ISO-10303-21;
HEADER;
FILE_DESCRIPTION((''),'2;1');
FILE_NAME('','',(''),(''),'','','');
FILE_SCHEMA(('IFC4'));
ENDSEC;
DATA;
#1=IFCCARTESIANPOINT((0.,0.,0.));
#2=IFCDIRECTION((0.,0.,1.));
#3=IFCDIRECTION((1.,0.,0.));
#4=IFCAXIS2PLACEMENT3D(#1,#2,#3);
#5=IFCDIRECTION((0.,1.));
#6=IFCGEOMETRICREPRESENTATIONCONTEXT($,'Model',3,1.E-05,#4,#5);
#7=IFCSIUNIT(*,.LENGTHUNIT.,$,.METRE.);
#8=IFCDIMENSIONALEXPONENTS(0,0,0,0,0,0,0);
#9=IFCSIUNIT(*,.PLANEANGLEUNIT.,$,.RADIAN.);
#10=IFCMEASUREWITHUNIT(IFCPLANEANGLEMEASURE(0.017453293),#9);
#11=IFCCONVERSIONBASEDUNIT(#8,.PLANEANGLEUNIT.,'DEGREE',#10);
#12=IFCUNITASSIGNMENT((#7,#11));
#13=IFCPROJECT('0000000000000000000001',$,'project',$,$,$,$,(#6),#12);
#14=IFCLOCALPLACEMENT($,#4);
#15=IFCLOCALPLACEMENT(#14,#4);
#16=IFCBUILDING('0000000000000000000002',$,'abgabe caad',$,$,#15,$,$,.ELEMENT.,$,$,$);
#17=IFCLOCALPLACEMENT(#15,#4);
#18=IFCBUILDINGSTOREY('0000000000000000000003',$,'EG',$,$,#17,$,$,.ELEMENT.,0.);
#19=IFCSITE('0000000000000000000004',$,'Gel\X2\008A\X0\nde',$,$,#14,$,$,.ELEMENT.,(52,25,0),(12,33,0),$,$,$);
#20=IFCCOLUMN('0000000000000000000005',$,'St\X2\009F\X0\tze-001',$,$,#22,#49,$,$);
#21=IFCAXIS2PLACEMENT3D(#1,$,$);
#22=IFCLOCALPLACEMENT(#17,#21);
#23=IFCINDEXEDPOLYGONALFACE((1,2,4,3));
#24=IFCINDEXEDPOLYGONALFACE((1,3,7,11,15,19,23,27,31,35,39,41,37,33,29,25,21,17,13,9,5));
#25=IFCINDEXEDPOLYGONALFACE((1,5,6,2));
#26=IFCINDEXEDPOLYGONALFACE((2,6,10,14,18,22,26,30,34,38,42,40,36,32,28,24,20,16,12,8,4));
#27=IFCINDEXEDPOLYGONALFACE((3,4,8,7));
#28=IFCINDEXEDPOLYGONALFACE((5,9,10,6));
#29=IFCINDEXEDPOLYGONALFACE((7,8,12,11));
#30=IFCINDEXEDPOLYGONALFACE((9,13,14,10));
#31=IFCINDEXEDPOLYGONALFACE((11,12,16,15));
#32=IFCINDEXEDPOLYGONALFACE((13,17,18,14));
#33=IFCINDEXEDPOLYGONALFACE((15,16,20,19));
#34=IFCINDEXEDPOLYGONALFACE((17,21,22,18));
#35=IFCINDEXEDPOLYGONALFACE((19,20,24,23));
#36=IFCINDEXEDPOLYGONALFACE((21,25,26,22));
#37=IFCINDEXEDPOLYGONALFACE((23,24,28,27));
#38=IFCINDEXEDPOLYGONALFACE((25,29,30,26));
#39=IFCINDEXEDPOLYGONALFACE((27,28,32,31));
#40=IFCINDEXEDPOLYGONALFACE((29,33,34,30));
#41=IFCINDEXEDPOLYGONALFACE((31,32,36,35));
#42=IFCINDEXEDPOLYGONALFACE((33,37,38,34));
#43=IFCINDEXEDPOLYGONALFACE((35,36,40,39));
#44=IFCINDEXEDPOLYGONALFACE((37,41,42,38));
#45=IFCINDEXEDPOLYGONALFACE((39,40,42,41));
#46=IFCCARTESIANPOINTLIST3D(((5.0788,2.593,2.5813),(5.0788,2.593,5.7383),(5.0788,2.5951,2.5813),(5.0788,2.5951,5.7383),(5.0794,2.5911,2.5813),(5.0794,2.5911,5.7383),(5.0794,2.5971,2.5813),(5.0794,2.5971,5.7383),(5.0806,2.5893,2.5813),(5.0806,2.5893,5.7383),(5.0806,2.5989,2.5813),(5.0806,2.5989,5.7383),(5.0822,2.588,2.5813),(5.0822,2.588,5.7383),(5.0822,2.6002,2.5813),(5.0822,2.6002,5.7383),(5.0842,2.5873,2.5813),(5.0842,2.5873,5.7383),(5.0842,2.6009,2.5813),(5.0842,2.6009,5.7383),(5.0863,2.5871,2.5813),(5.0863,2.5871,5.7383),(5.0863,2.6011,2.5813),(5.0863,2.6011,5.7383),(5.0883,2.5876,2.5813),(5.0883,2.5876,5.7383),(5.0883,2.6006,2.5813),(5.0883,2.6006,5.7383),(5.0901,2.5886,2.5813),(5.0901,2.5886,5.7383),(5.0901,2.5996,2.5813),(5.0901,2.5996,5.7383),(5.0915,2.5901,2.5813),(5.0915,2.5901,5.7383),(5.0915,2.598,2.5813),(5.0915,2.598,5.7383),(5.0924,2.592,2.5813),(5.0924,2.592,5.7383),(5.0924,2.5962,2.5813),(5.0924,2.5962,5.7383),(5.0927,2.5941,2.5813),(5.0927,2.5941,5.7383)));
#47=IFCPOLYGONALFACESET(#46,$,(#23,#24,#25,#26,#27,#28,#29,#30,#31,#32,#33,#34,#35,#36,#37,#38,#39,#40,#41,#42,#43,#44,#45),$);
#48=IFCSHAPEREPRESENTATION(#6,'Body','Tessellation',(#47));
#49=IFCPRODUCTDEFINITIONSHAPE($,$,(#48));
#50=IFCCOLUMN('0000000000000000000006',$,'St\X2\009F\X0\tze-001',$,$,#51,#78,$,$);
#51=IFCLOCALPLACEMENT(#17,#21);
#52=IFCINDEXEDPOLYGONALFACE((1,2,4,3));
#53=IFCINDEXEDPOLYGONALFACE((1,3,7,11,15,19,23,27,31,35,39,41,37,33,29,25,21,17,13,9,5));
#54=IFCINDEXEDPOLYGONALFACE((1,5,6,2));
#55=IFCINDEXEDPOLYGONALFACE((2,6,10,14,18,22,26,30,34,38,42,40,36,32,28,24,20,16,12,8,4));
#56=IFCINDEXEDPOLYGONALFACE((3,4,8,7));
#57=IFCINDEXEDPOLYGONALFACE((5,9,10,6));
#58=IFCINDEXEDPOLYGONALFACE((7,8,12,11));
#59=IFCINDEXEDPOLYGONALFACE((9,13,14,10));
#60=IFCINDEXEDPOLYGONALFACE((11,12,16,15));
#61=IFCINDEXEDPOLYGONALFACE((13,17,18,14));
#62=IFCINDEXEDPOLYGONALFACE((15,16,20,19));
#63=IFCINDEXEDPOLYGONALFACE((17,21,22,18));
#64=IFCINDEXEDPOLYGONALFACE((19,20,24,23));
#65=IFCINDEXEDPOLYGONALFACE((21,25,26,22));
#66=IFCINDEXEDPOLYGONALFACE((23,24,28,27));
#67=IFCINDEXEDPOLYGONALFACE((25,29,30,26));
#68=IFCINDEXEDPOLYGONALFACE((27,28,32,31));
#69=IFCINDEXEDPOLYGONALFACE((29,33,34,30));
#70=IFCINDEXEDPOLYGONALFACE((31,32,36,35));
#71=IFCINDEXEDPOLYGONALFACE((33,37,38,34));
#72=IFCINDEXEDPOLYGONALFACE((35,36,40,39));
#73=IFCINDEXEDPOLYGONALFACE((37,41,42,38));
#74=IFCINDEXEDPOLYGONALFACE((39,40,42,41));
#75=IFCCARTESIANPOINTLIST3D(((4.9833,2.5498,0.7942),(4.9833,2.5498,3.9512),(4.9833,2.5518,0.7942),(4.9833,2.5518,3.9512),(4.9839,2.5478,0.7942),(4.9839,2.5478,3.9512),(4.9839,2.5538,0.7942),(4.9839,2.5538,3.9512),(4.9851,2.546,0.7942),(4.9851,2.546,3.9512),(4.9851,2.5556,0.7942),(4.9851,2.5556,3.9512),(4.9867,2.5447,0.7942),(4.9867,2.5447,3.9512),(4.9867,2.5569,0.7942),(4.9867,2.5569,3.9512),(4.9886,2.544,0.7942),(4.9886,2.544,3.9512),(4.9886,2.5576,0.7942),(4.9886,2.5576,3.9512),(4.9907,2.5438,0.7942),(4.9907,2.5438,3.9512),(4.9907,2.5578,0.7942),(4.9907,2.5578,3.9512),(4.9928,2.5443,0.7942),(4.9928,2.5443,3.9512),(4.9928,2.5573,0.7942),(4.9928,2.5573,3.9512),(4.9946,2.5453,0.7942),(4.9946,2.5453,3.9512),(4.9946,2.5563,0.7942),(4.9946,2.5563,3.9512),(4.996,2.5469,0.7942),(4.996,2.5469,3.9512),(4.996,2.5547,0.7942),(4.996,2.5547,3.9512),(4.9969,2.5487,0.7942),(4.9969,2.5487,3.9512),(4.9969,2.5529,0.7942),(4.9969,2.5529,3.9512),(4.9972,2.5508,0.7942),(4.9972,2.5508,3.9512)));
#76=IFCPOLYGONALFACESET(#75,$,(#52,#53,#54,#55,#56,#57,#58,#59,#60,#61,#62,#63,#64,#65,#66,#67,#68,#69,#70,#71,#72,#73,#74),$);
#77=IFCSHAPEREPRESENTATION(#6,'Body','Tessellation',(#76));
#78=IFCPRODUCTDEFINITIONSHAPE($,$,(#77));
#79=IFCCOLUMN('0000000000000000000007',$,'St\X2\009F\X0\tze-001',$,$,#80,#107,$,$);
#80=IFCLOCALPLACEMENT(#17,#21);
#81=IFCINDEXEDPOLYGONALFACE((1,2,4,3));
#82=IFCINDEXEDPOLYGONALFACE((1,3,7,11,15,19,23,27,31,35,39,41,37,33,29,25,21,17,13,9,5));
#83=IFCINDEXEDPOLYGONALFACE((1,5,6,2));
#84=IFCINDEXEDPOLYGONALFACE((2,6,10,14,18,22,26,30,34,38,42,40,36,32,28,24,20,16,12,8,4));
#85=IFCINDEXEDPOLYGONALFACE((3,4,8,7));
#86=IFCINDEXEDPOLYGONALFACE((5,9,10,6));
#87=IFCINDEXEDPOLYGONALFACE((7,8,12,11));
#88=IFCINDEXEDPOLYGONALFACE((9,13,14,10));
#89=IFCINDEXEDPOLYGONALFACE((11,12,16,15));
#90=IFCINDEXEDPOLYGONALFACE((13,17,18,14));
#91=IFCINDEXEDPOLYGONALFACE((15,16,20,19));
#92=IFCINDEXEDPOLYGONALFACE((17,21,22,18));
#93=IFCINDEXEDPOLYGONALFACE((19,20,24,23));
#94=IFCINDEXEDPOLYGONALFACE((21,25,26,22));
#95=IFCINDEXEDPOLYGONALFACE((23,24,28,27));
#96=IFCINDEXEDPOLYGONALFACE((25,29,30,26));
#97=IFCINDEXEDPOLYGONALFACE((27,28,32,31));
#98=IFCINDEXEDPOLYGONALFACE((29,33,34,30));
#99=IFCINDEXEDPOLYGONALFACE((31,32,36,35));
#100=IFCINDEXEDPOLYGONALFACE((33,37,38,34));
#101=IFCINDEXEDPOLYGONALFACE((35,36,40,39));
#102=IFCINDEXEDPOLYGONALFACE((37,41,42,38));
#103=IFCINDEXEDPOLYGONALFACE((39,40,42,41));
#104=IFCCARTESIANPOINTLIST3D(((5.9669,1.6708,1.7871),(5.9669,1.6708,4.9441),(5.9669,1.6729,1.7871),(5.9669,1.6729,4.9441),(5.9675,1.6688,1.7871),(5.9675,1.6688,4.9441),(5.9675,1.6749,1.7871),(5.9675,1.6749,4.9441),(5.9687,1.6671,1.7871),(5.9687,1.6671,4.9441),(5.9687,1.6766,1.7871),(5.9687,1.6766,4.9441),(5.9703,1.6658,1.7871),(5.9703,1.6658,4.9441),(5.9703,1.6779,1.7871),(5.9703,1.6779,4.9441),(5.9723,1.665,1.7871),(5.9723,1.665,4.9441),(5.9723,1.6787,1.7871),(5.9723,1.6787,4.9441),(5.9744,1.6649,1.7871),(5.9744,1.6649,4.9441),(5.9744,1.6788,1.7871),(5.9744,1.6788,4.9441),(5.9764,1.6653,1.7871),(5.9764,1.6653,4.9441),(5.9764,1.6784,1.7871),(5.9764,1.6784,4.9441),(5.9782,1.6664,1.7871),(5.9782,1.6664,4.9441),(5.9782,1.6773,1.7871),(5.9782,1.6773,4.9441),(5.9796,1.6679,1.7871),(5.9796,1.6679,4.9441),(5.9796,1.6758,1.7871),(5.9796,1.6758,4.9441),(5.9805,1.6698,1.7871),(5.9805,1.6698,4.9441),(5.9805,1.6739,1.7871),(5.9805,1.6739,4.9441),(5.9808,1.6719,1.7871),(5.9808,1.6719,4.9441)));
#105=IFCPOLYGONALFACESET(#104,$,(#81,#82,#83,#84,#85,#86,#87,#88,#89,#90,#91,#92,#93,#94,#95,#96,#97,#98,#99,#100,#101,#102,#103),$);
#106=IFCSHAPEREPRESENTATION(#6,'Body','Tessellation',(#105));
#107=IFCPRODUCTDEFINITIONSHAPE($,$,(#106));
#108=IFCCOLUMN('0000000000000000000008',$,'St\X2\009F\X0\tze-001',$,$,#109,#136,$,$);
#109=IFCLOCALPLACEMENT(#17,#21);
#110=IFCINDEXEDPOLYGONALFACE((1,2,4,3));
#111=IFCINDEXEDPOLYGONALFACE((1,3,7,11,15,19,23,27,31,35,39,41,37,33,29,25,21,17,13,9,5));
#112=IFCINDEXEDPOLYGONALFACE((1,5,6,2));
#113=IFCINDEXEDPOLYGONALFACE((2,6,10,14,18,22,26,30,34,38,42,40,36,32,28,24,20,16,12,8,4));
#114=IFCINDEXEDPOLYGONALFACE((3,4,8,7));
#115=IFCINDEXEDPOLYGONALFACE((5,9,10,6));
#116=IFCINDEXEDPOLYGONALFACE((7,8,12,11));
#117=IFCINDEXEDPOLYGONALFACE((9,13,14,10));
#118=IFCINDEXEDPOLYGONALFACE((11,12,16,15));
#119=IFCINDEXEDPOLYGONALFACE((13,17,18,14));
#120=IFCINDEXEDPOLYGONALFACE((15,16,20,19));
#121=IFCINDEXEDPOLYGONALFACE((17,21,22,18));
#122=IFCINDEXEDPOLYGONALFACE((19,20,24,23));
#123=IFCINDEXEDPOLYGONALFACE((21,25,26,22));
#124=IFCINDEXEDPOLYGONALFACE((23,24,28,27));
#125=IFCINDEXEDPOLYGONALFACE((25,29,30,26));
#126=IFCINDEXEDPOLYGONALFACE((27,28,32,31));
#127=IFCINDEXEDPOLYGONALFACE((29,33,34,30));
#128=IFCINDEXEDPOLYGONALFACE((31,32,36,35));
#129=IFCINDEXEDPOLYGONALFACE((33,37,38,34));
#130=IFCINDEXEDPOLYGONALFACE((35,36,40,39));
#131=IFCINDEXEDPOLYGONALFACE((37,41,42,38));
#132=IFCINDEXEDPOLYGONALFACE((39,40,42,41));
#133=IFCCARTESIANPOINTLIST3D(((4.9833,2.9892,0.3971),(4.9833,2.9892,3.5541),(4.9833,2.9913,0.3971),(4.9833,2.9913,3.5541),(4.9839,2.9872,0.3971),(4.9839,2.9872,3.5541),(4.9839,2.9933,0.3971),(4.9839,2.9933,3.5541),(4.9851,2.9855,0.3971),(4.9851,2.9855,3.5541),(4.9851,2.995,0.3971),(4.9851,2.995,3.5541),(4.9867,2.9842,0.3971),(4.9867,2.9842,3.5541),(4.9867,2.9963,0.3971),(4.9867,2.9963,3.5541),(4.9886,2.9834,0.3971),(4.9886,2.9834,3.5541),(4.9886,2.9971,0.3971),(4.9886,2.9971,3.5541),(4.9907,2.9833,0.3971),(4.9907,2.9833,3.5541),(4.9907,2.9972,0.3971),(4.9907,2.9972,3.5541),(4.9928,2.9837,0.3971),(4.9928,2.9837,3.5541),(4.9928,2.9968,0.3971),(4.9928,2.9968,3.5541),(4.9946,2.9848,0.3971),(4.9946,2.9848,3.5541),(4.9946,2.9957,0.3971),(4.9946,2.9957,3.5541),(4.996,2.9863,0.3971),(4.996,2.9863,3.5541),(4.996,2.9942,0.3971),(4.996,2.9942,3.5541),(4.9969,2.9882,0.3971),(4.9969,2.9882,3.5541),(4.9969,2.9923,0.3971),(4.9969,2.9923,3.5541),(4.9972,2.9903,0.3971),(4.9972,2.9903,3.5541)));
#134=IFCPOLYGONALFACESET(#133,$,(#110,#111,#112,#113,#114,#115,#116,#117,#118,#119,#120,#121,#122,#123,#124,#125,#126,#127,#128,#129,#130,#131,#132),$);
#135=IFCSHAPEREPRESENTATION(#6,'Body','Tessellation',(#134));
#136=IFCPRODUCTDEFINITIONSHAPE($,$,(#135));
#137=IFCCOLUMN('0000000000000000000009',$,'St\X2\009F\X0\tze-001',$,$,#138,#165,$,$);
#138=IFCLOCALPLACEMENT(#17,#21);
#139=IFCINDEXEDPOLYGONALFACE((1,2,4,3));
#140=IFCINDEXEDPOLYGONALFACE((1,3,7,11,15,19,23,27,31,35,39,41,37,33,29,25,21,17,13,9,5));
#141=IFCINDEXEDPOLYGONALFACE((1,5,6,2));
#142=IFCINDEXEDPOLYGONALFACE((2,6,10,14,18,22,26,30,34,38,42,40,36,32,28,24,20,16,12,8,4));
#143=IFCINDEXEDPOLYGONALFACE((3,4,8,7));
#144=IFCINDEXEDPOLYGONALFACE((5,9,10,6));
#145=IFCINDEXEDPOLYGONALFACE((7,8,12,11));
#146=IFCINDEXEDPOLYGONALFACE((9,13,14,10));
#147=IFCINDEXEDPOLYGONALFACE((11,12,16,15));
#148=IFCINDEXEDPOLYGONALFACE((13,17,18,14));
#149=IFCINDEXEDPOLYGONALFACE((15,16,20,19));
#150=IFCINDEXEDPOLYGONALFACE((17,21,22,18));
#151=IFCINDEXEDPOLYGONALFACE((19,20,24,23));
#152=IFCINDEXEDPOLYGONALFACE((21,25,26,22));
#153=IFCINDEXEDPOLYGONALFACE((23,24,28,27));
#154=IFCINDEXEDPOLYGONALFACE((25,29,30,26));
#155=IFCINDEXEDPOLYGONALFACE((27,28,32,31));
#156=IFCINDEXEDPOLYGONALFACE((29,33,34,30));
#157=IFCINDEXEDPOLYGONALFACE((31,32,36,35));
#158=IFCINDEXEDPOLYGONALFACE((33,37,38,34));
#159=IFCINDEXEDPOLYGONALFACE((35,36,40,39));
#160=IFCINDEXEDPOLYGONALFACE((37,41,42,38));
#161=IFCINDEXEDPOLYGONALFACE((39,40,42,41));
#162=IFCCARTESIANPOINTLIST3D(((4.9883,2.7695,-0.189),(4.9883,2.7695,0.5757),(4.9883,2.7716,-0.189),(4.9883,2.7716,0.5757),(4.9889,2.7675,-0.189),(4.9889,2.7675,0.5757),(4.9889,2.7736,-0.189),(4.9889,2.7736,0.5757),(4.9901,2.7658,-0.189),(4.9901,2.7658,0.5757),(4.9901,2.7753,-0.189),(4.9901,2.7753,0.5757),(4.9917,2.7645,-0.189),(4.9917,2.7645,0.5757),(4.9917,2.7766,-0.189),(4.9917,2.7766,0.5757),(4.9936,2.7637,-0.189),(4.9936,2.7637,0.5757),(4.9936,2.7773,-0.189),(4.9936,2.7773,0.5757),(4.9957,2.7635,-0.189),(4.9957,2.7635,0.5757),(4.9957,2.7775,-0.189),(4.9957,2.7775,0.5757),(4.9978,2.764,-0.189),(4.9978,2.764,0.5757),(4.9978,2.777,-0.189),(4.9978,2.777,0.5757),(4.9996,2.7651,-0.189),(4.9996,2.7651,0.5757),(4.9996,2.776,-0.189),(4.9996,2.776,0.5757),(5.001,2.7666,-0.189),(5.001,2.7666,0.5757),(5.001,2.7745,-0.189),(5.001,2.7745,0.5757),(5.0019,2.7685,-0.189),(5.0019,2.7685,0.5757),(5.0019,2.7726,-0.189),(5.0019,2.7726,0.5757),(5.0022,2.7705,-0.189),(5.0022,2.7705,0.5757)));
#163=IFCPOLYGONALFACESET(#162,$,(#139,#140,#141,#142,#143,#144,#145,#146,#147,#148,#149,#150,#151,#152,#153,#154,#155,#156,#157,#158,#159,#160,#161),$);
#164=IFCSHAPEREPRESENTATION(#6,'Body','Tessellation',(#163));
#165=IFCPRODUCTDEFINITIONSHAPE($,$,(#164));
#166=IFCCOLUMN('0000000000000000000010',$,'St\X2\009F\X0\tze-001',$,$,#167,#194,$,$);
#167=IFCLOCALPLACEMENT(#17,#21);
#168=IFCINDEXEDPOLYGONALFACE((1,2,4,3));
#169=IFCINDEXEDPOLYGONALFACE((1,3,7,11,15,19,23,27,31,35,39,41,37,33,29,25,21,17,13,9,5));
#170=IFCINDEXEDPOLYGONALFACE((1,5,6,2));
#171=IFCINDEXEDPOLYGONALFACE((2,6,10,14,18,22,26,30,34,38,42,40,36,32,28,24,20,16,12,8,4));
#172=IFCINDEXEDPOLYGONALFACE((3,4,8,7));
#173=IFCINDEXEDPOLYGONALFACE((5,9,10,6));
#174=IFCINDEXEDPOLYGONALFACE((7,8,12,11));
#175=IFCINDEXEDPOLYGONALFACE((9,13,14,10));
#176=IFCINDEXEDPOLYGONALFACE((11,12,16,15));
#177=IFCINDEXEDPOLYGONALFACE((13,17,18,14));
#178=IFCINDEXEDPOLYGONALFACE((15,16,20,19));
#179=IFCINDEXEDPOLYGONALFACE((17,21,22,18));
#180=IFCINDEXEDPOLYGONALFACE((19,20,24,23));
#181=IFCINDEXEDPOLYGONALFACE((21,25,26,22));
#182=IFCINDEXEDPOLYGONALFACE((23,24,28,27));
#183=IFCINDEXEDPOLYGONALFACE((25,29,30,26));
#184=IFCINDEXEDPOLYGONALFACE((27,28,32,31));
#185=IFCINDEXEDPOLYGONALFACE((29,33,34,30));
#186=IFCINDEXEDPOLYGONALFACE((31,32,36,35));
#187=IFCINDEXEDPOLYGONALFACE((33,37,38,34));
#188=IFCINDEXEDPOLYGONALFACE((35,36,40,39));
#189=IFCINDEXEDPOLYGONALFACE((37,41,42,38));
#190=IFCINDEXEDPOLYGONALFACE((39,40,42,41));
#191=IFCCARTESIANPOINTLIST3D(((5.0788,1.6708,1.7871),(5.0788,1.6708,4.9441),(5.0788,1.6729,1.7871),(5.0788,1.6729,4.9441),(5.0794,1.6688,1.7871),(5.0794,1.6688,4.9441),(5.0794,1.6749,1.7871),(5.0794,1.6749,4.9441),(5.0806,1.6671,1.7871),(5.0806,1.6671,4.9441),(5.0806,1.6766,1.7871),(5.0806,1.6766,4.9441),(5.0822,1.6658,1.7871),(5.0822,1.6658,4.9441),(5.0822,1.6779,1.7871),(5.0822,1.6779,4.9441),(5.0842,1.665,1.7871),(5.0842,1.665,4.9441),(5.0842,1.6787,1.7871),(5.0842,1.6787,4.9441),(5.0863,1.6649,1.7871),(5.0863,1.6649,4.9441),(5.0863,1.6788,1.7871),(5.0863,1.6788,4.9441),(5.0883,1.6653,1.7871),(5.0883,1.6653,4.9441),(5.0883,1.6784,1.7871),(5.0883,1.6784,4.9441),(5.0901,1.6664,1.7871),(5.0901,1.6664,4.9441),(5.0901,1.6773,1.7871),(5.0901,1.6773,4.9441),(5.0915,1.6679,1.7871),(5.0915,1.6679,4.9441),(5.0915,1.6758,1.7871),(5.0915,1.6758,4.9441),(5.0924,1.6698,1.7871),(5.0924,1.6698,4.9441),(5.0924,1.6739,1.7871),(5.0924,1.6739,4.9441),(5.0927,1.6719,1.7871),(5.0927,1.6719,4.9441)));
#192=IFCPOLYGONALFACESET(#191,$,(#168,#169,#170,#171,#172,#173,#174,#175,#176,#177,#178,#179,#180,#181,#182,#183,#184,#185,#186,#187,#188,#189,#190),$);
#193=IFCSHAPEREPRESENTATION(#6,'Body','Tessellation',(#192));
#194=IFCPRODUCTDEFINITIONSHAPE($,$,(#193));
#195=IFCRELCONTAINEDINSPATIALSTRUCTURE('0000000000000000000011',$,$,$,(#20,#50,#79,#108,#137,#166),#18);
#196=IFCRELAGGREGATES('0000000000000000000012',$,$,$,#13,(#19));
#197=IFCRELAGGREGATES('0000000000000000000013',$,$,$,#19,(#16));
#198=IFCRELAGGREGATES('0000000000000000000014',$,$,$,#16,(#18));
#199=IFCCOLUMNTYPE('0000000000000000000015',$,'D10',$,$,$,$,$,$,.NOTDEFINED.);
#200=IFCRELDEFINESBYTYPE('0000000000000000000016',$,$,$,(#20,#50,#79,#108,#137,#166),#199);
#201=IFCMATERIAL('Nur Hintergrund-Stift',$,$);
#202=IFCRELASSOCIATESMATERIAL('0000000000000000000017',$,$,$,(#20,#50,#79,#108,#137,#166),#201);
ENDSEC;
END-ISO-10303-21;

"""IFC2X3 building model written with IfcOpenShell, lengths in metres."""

from ifc_helpers import new_model, entity, si_unit, converted_unit, direction, frame, origin_with_axes, origin_2d_with_axis, place, context, project, spatial, circle, extrude, material, type_object, element, save


model = new_model("IFC2X3")

# Units and contexts
model_context = context("Model", 3, precision=1e-05, world=origin_with_axes(), true_north=direction((0.0, 1.0)))
ifc_project = project(units=[si_unit("LENGTHUNIT", "METRE"), converted_unit("PLANEANGLEUNIT", "DEGREE", entity("IfcPlaneAngleMeasure", 0.017453293), si_unit("PLANEANGLEUNIT", "RADIAN"), dimensions=[0, 0, 0, 0, 0, 0, 0])], contexts=[model_context])

# Site, building, storey
site_placement = place(None, origin_with_axes())
site = spatial("IfcSite", under=ifc_project, at=site_placement, Name="Gel\u008ande", CompositionType="ELEMENT", RefLatitude=(52, 25, 0), RefLongitude=(12, 33, 0))
building_placement = place(site_placement, origin_with_axes())
building = spatial("IfcBuilding", under=site, at=building_placement, Name="abgabe caad", CompositionType="ELEMENT")
storey_placement = place(building_placement, origin_with_axes())
storey = spatial("IfcBuildingStorey", under=building, at=storey_placement, Name="EG", CompositionType="ELEMENT", Elevation=0.0)

# Columns
ifc_material_1 = material(Name="Nur Hintergrund-Stift")
column_type = type_object("IfcColumnType", Name="D10", PredefinedType="NOTDEFINED")
for number, where, z_axis, x_axis, name in (
    (1, (5.0857, 2.5941, 2.5813), (0.0, 0.0, 1.0), (1.0, 0.0, 0.0), "St\u009ftze-001"),
    (2, (4.9902, 2.5508, 0.7943), (0.0, 0.0, 1.0), (1.0, 0.0, 0.0), "St\u009ftze-001"),
    (3, (5.9738, 1.6719, 1.7871), (0.0, 0.0, 1.0), (1.0, 0.0, 0.0), "St\u009ftze-001"),
    (4, (4.9902, 2.9903, 0.3971), (0.0, 0.0, 1.0), (1.0, 0.0, 0.0), "St\u009ftze-001"),
):
    element("IfcColumn", number, at=place(storey_placement, frame(where, z_axis=z_axis, x_axis=x_axis)), inside=storey, type_object=column_type, material=ifc_material_1, Name=name, context=model_context, shape_type="SweptSolid", body=[
        extrude(circle(Radius=0.007, at=origin_2d_with_axis()), origin_with_axes(), (0.0, 0.0, 1.0), 3.157),
    ])
column_1_placement = place(storey_placement, frame((4.9952, 2.7705, -0.189), z_axis=(0.0, 0.0, 1.0), x_axis=(1.0, 0.0, 0.0)))
element("IfcColumn", 5, at=column_1_placement, inside=storey, type_object=column_type, material=ifc_material_1, Name="St\u009ftze-001", context=model_context, shape_type="SweptSolid", body=[
    extrude(circle(Radius=0.007, at=origin_2d_with_axis()), origin_with_axes(), (0.0, 0.0, 1.0), 0.7647),
])
for number, where, z_axis, x_axis, name in (
    (6, (5.0857, 1.6719, 1.7871), (0.0, 0.0, 1.0), (1.0, 0.0, 0.0), "St\u009ftze-001"),
):
    element("IfcColumn", number, at=place(storey_placement, frame(where, z_axis=z_axis, x_axis=x_axis)), inside=storey, type_object=column_type, material=ifc_material_1, Name=name, context=model_context, shape_type="SweptSolid", body=[
        extrude(circle(Radius=0.007, at=origin_2d_with_axis()), origin_with_axes(), (0.0, 0.0, 1.0), 3.157),
    ])

save(model, "model.ifc")
